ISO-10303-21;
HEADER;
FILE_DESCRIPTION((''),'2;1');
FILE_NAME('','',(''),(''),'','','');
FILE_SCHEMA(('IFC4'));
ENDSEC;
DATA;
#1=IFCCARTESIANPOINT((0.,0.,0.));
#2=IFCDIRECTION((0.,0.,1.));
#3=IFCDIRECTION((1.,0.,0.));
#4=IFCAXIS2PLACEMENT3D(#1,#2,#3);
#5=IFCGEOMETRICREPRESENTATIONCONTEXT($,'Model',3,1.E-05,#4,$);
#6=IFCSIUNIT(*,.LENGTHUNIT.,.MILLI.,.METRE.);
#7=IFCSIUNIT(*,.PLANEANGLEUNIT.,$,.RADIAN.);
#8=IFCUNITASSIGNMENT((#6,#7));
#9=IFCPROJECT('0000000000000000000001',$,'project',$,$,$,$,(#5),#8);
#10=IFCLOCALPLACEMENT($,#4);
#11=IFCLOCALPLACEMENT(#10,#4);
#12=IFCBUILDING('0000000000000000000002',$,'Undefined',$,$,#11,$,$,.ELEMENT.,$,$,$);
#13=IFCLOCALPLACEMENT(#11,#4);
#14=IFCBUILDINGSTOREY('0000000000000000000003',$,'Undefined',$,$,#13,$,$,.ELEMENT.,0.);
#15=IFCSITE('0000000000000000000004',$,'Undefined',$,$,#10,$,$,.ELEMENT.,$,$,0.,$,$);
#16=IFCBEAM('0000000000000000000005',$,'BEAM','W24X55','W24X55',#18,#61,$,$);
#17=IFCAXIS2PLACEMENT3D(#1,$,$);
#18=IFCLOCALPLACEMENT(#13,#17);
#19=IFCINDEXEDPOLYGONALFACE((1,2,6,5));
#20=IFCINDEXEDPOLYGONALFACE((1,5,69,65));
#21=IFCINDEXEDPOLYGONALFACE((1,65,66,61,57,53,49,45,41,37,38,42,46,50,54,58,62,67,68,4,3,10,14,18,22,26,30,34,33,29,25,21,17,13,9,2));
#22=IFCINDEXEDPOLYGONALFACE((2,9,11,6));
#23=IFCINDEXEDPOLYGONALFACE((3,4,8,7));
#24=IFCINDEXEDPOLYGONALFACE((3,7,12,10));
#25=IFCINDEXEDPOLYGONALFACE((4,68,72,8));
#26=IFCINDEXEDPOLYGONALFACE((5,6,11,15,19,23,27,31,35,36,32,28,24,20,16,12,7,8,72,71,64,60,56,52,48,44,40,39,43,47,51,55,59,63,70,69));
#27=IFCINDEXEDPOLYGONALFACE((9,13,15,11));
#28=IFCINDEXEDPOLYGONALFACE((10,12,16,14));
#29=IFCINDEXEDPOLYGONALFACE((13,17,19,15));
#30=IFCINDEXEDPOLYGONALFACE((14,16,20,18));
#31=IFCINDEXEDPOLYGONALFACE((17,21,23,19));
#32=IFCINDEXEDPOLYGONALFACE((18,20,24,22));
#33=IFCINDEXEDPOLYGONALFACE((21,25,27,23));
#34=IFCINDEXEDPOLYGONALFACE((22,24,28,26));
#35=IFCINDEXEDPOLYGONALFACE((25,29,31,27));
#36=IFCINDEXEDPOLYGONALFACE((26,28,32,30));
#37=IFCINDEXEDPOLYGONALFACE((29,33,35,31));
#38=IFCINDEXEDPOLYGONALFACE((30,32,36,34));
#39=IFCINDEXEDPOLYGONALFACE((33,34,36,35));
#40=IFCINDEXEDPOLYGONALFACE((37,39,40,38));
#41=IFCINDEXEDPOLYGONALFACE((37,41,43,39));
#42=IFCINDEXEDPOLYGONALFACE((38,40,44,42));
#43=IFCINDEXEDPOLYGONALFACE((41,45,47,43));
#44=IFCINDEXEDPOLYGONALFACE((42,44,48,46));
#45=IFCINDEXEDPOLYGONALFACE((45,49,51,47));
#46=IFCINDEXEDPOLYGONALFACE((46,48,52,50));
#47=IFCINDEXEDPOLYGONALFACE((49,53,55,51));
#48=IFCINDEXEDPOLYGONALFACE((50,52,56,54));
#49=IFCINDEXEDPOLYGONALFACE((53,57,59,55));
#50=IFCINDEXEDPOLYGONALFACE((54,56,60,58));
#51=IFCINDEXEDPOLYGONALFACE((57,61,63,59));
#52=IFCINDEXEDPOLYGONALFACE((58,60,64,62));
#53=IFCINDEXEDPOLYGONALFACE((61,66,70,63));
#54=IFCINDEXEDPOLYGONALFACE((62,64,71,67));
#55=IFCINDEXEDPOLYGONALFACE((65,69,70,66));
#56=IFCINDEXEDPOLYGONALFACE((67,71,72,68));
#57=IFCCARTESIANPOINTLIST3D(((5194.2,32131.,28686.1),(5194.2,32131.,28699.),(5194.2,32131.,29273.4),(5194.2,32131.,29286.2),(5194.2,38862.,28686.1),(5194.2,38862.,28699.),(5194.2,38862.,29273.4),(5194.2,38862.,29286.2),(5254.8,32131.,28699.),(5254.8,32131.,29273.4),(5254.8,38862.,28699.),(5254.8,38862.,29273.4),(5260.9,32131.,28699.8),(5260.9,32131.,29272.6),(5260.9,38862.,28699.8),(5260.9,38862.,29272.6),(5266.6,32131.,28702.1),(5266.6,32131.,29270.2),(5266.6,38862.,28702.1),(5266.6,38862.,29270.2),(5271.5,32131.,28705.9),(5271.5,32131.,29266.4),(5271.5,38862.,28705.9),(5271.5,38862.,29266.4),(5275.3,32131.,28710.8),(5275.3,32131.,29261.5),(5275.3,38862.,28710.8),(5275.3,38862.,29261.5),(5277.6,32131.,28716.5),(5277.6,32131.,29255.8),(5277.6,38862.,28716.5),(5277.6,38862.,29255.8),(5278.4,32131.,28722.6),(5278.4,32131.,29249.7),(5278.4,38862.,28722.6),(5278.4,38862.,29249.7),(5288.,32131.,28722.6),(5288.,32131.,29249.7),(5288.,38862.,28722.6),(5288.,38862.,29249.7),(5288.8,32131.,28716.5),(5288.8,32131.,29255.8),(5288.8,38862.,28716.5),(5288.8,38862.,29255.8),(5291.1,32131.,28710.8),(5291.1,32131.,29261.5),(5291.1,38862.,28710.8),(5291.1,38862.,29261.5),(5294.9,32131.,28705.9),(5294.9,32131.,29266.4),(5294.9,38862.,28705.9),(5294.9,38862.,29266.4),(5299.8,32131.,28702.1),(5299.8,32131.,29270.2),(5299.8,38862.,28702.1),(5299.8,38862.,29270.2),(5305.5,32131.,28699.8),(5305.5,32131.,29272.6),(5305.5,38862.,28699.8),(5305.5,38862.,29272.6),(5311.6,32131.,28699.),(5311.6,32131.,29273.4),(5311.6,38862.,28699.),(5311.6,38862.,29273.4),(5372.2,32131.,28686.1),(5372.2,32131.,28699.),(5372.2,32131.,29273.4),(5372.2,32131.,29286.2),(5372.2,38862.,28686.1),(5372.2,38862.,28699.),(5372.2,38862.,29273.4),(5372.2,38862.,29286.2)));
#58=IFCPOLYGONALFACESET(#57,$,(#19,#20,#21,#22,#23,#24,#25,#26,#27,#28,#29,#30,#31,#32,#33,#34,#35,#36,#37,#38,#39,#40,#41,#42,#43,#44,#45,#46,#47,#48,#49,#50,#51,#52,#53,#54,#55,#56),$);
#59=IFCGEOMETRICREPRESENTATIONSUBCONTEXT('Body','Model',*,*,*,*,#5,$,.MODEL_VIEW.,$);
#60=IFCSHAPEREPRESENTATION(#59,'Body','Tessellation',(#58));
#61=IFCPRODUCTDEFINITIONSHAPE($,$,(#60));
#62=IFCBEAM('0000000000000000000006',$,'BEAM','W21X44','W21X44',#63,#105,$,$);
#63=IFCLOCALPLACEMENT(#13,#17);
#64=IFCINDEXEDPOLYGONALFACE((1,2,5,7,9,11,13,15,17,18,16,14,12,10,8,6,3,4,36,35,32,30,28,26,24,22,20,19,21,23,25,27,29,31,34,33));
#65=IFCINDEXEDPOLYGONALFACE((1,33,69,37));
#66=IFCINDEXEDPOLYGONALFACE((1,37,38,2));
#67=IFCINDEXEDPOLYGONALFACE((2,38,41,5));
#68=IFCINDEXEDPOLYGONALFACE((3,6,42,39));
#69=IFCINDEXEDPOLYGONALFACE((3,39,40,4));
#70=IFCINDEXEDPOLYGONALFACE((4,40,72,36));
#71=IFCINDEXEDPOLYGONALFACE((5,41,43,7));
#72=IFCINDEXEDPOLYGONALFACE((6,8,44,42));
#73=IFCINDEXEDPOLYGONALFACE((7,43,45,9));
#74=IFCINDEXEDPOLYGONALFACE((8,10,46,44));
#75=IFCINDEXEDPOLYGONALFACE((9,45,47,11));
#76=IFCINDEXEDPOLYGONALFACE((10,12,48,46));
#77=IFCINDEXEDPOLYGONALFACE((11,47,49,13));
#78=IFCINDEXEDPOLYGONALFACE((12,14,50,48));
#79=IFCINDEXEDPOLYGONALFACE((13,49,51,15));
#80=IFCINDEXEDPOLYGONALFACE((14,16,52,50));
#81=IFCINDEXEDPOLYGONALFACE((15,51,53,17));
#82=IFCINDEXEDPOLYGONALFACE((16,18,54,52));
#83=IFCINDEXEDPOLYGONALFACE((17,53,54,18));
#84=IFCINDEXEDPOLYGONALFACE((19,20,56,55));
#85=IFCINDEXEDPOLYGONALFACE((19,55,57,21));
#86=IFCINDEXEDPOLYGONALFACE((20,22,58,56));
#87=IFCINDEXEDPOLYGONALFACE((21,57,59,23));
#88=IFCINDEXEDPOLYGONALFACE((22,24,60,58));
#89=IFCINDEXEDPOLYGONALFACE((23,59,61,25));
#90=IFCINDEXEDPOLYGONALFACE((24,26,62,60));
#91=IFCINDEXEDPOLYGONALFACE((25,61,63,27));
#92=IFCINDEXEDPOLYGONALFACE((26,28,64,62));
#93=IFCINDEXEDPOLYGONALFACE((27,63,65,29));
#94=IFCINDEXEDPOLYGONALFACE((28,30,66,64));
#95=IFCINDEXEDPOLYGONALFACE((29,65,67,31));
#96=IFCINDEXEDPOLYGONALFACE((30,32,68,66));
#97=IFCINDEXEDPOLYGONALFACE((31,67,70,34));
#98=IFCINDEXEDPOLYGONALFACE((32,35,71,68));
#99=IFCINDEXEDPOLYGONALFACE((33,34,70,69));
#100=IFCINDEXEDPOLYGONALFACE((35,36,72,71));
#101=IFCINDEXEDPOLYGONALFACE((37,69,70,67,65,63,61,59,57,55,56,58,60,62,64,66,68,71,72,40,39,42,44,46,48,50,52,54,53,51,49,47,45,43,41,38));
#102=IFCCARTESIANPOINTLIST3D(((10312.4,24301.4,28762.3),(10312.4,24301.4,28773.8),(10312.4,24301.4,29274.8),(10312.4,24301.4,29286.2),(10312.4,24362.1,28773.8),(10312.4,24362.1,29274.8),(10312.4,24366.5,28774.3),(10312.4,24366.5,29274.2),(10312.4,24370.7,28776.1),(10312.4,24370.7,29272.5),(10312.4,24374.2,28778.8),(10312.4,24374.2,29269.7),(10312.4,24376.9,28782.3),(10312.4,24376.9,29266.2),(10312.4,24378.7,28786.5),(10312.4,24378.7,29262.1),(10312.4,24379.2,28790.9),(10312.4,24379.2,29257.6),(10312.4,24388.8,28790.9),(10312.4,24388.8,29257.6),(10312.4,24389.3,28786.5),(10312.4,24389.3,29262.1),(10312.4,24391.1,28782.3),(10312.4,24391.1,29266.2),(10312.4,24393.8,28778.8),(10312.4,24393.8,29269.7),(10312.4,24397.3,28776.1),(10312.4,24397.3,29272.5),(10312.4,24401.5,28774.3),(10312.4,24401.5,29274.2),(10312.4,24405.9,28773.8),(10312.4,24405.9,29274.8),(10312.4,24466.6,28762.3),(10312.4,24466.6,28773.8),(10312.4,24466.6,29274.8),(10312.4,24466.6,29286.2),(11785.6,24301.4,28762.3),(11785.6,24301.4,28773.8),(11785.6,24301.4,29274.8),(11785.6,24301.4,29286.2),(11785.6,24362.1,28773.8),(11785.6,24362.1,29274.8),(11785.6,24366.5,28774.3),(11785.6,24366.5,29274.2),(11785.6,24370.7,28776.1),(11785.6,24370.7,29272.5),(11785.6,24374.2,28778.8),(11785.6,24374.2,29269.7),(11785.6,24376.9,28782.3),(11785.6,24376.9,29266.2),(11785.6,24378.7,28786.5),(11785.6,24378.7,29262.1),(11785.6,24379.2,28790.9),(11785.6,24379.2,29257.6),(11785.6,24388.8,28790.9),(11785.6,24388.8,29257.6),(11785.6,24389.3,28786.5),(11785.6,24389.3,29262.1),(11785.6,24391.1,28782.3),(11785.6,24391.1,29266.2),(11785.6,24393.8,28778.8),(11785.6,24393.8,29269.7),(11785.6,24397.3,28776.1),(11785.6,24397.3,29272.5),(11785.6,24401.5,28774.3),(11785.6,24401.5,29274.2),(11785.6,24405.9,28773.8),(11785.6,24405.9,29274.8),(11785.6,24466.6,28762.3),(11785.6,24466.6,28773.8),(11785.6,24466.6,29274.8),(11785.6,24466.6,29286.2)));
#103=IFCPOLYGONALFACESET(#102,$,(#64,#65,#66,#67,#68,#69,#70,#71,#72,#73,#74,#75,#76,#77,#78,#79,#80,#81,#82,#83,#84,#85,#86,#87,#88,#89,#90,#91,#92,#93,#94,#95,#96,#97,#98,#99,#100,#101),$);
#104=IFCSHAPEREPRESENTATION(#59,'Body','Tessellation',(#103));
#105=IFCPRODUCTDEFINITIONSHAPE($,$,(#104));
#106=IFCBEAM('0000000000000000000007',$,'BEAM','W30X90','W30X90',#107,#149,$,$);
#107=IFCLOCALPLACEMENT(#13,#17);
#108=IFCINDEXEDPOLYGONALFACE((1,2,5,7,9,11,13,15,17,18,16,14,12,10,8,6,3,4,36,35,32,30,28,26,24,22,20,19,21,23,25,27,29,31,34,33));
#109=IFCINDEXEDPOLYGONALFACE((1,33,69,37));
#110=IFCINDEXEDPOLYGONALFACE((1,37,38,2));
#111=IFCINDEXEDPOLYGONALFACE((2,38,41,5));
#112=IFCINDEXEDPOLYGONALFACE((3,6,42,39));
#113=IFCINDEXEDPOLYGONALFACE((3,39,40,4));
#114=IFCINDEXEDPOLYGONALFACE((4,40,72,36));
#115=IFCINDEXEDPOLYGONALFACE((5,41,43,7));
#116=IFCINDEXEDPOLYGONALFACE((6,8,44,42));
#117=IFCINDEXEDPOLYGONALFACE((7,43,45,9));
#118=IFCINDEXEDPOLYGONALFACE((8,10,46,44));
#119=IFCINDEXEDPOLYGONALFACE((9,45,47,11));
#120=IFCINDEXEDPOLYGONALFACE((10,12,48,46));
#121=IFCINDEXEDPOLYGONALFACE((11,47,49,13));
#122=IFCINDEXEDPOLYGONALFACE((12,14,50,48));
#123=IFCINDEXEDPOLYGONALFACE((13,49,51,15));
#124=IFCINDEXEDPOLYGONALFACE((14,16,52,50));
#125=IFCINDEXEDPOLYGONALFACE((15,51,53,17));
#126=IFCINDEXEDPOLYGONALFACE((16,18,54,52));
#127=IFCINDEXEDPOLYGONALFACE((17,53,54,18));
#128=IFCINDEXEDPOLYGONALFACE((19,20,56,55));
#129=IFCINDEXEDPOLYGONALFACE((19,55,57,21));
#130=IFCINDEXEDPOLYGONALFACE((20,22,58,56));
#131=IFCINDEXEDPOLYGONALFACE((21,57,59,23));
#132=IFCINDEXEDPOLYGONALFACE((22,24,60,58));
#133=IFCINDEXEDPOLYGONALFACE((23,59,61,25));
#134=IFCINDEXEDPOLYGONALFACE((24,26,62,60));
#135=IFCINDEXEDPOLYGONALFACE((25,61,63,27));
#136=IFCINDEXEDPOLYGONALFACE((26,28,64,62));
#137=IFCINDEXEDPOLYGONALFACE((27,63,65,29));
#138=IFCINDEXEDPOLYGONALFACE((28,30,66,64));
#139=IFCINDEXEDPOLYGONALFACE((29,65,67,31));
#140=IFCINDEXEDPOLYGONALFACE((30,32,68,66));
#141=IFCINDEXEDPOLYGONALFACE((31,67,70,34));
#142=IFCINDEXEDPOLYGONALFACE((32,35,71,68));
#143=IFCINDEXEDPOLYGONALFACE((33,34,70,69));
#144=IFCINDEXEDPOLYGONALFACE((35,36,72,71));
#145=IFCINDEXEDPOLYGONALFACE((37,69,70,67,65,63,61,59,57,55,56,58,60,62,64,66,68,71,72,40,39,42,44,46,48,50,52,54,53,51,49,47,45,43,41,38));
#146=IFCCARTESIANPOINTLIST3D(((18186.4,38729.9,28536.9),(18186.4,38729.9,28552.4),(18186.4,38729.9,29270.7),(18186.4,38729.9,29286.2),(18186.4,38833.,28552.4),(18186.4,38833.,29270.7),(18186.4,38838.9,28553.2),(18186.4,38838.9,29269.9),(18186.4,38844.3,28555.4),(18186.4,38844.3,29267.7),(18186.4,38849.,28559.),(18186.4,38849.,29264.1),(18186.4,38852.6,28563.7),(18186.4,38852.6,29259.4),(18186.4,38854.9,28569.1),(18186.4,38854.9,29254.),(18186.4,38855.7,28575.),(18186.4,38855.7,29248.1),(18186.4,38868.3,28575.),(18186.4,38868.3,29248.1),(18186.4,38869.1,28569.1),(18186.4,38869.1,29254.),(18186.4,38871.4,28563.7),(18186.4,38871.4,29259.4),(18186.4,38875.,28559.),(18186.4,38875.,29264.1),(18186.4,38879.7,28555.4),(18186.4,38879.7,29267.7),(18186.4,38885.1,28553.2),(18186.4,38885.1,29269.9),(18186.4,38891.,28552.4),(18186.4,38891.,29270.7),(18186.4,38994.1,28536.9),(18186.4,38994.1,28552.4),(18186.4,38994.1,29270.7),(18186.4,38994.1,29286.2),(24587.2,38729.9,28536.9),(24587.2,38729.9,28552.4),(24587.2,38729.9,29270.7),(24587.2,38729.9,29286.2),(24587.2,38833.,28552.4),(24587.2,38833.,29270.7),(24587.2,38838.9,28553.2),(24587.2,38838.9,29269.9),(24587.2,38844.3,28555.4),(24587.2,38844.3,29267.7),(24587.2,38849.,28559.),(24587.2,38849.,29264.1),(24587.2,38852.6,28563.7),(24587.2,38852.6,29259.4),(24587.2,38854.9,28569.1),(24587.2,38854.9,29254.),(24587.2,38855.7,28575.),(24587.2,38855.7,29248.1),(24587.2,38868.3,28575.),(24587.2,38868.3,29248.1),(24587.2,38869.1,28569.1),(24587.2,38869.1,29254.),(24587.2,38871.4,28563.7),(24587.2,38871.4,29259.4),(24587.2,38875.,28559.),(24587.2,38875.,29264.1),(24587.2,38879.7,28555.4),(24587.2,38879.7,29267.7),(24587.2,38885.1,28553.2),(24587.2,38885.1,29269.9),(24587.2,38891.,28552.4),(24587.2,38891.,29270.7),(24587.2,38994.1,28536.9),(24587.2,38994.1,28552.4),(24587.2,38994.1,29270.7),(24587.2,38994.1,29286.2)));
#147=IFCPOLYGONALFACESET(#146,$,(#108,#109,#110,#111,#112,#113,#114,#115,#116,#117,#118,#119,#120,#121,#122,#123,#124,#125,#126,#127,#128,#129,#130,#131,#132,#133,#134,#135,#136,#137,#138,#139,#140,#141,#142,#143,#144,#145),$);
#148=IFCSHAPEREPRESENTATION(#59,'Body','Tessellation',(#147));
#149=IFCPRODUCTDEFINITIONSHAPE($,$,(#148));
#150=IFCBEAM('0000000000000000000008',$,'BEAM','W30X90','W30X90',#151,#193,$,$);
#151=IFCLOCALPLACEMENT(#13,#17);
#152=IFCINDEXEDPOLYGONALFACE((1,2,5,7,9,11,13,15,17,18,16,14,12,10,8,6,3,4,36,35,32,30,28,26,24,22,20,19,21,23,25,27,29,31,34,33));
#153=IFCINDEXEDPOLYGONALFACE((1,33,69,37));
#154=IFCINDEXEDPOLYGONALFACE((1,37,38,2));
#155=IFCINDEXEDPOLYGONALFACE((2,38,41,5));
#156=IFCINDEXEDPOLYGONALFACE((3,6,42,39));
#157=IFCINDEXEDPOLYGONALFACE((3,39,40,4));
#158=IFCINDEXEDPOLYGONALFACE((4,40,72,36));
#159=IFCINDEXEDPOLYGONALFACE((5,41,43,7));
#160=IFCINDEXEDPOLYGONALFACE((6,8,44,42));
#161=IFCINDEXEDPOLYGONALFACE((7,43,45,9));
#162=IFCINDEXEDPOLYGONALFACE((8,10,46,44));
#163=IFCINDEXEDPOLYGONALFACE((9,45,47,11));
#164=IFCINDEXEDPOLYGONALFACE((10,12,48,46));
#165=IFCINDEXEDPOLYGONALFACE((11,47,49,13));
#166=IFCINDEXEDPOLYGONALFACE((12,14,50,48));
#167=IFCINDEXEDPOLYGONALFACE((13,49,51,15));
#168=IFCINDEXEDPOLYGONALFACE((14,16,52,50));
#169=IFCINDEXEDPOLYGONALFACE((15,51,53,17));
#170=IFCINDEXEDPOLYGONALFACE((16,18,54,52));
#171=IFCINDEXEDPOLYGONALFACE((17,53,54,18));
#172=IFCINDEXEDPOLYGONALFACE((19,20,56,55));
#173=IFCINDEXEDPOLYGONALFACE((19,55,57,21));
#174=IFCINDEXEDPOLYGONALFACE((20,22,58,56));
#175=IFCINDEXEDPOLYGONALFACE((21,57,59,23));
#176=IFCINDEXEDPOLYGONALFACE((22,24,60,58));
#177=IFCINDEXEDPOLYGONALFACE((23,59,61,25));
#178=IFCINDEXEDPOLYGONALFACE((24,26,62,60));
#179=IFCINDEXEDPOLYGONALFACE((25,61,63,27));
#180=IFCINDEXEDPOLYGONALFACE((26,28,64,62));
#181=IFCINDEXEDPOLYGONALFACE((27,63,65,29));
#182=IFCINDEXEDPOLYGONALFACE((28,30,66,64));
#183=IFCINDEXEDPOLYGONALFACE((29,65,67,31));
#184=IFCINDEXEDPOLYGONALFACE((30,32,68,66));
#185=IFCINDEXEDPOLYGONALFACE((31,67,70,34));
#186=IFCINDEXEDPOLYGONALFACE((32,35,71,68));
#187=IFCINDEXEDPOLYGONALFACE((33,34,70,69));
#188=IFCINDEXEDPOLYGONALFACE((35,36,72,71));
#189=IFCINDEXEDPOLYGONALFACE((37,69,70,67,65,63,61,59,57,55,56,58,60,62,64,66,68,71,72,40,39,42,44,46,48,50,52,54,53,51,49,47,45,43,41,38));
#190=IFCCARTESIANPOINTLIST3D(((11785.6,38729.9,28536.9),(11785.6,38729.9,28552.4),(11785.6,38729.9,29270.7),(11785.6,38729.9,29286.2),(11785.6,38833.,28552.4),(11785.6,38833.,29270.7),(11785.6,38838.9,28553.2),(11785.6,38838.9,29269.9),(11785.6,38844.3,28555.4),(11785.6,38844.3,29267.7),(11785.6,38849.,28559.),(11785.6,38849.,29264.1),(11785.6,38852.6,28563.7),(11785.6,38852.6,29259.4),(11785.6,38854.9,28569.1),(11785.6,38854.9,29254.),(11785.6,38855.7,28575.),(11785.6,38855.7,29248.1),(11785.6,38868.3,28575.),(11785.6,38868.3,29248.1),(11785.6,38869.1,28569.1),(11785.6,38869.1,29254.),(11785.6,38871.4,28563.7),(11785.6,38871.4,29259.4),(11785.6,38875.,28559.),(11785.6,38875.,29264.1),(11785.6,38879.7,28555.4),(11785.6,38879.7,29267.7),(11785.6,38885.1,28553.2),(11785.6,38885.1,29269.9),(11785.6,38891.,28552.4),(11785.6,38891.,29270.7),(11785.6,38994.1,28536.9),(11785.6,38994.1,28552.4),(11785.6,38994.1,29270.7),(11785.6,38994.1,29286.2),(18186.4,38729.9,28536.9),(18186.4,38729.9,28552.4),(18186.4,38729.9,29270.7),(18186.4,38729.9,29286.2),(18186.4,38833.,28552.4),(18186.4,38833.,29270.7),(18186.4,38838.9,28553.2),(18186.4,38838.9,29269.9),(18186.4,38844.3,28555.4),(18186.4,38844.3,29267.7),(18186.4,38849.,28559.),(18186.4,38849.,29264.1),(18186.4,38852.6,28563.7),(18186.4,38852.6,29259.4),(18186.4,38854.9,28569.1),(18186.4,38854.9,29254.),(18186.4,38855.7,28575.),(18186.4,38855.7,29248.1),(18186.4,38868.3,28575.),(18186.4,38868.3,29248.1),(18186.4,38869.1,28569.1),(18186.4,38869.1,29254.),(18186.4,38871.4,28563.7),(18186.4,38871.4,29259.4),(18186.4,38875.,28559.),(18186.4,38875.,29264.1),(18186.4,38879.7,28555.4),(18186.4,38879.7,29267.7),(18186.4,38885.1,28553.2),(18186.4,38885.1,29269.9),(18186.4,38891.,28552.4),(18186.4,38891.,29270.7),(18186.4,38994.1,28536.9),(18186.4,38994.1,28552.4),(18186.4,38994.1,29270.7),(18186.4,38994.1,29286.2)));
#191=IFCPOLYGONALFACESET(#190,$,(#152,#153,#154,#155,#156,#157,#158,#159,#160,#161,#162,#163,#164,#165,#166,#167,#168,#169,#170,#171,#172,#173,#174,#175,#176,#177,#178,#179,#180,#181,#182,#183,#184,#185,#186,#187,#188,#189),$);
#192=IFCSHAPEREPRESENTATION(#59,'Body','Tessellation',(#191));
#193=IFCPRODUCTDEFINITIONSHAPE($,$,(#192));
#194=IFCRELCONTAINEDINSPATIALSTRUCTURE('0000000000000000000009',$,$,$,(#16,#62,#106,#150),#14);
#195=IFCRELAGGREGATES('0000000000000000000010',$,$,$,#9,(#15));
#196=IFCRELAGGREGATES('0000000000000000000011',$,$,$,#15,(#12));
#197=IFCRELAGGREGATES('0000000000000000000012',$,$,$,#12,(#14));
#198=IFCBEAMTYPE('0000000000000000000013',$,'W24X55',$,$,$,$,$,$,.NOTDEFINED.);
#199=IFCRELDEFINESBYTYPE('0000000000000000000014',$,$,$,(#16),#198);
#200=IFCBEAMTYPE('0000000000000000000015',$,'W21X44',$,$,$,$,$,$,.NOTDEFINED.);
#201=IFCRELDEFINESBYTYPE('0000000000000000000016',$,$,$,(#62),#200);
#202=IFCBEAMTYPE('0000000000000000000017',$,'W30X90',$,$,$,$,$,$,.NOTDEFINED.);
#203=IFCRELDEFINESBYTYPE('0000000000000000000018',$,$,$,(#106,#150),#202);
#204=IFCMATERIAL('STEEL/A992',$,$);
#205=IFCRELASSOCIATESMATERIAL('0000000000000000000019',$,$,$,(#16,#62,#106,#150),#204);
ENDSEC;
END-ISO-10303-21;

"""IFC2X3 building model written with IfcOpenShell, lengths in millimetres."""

from ifc_helpers import new_model, si_unit, frame, origin_with_axes, origin_2d_with_axis, place, context, subcontext, project, spatial, i_section, extrude, material, type_object, element, save


model = new_model("IFC2X3")

# Units and contexts
model_context = context("Model", 3, precision=1e-05, world=origin_with_axes())
body_context = subcontext(model_context, "Body", "Model", "MODEL_VIEW")
ifc_project = project(units=[si_unit("LENGTHUNIT", "METRE", prefix="MILLI"), si_unit("PLANEANGLEUNIT", "RADIAN")], contexts=[model_context])

# Site, building, storey
site_placement = place(None, origin_with_axes())
site = spatial("IfcSite", under=ifc_project, at=site_placement, Name="Undefined", CompositionType="ELEMENT", RefElevation=0.0)
building_placement = place(site_placement, origin_with_axes())
building = spatial("IfcBuilding", under=site, at=building_placement, Name="Undefined", CompositionType="ELEMENT")
storey_placement = place(building_placement, origin_with_axes())
storey = spatial("IfcBuildingStorey", under=building, at=storey_placement, Name="Undefined", CompositionType="ELEMENT", Elevation=0.0)

# Shared definitions
ifc_material_1 = material(Name="STEEL/A992")

# Beams
beam_type_1 = type_object("IfcBeamType", Name="W24X55", PredefinedType="NOTDEFINED")
for number, where, z_axis, x_axis, name in (
    (1, (5283.2, 32131.0, 28986.2), (0.0, 0.0, 1.0), (0.0, 1.0, 0.0), "BEAM"),
):
    element("IfcBeam", number, at=place(storey_placement, frame(where, z_axis=z_axis, x_axis=x_axis)), inside=storey, type_object=beam_type_1, material=ifc_material_1, Name=name, Description="W24X55", ObjectType="W24X55", context=body_context, shape_type="SweptSolid", body=[
        extrude(i_section(OverallWidth=178.1, OverallDepth=600.1, WebThickness=9.5, FlangeThickness=12.8, FilletRadius=23.7, at=origin_2d_with_axis()), frame((6731.0, 0.0, 0.0), z_axis=(-1.0, 0.0, 0.0), x_axis=(0.0, -1.0, 0.0)), (0.0, 0.0, 1.0), 6731.0),
    ])
beam_type_2 = type_object("IfcBeamType", Name="W21X44", PredefinedType="NOTDEFINED")
beam_1_placement = place(storey_placement, frame((10312.4, 24384.0, 29024.3), z_axis=(0.0, 0.0, 1.0), x_axis=(1.0, 0.0, 0.0)))
element("IfcBeam", 2, at=beam_1_placement, inside=storey, type_object=beam_type_2, material=ifc_material_1, Name="BEAM", Description="W21X44", ObjectType="W21X44", context=body_context, shape_type="SweptSolid", body=[
    extrude(i_section(OverallWidth=165.1, OverallDepth=523.9, WebThickness=9.5, FlangeThickness=11.4, FilletRadius=17.1, at=origin_2d_with_axis()), frame((1473.2, 0.0, 0.0), z_axis=(-1.0, 0.0, 0.0), x_axis=(0.0, -1.0, 0.0)), (0.0, 0.0, 1.0), 1473.2),
])
beam_type_3 = type_object("IfcBeamType", Name="W30X90", PredefinedType="NOTDEFINED")
for number, where, z_axis, x_axis, name in (
    (3, (18186.4, 38862.0, 28911.5), (0.0, 0.0, 1.0), (1.0, 0.0, 0.0), "BEAM"),
    (4, (11785.6, 38862.0, 28911.5), (0.0, 0.0, 1.0), (1.0, 0.0, 0.0), "BEAM"),
):
    element("IfcBeam", number, at=place(storey_placement, frame(where, z_axis=z_axis, x_axis=x_axis)), inside=storey, type_object=beam_type_3, material=ifc_material_1, Name=name, Description="W30X90", ObjectType="W30X90", context=body_context, shape_type="SweptSolid", body=[
        extrude(i_section(OverallWidth=264.2, OverallDepth=749.3, WebThickness=12.7, FlangeThickness=15.5, FilletRadius=22.6, at=origin_2d_with_axis()), frame((6400.8, 0.0, 0.0), z_axis=(-1.0, 0.0, 0.0), x_axis=(0.0, -1.0, 0.0)), (0.0, 0.0, 1.0), 6400.8),
    ])

save(model, "model.ifc")
